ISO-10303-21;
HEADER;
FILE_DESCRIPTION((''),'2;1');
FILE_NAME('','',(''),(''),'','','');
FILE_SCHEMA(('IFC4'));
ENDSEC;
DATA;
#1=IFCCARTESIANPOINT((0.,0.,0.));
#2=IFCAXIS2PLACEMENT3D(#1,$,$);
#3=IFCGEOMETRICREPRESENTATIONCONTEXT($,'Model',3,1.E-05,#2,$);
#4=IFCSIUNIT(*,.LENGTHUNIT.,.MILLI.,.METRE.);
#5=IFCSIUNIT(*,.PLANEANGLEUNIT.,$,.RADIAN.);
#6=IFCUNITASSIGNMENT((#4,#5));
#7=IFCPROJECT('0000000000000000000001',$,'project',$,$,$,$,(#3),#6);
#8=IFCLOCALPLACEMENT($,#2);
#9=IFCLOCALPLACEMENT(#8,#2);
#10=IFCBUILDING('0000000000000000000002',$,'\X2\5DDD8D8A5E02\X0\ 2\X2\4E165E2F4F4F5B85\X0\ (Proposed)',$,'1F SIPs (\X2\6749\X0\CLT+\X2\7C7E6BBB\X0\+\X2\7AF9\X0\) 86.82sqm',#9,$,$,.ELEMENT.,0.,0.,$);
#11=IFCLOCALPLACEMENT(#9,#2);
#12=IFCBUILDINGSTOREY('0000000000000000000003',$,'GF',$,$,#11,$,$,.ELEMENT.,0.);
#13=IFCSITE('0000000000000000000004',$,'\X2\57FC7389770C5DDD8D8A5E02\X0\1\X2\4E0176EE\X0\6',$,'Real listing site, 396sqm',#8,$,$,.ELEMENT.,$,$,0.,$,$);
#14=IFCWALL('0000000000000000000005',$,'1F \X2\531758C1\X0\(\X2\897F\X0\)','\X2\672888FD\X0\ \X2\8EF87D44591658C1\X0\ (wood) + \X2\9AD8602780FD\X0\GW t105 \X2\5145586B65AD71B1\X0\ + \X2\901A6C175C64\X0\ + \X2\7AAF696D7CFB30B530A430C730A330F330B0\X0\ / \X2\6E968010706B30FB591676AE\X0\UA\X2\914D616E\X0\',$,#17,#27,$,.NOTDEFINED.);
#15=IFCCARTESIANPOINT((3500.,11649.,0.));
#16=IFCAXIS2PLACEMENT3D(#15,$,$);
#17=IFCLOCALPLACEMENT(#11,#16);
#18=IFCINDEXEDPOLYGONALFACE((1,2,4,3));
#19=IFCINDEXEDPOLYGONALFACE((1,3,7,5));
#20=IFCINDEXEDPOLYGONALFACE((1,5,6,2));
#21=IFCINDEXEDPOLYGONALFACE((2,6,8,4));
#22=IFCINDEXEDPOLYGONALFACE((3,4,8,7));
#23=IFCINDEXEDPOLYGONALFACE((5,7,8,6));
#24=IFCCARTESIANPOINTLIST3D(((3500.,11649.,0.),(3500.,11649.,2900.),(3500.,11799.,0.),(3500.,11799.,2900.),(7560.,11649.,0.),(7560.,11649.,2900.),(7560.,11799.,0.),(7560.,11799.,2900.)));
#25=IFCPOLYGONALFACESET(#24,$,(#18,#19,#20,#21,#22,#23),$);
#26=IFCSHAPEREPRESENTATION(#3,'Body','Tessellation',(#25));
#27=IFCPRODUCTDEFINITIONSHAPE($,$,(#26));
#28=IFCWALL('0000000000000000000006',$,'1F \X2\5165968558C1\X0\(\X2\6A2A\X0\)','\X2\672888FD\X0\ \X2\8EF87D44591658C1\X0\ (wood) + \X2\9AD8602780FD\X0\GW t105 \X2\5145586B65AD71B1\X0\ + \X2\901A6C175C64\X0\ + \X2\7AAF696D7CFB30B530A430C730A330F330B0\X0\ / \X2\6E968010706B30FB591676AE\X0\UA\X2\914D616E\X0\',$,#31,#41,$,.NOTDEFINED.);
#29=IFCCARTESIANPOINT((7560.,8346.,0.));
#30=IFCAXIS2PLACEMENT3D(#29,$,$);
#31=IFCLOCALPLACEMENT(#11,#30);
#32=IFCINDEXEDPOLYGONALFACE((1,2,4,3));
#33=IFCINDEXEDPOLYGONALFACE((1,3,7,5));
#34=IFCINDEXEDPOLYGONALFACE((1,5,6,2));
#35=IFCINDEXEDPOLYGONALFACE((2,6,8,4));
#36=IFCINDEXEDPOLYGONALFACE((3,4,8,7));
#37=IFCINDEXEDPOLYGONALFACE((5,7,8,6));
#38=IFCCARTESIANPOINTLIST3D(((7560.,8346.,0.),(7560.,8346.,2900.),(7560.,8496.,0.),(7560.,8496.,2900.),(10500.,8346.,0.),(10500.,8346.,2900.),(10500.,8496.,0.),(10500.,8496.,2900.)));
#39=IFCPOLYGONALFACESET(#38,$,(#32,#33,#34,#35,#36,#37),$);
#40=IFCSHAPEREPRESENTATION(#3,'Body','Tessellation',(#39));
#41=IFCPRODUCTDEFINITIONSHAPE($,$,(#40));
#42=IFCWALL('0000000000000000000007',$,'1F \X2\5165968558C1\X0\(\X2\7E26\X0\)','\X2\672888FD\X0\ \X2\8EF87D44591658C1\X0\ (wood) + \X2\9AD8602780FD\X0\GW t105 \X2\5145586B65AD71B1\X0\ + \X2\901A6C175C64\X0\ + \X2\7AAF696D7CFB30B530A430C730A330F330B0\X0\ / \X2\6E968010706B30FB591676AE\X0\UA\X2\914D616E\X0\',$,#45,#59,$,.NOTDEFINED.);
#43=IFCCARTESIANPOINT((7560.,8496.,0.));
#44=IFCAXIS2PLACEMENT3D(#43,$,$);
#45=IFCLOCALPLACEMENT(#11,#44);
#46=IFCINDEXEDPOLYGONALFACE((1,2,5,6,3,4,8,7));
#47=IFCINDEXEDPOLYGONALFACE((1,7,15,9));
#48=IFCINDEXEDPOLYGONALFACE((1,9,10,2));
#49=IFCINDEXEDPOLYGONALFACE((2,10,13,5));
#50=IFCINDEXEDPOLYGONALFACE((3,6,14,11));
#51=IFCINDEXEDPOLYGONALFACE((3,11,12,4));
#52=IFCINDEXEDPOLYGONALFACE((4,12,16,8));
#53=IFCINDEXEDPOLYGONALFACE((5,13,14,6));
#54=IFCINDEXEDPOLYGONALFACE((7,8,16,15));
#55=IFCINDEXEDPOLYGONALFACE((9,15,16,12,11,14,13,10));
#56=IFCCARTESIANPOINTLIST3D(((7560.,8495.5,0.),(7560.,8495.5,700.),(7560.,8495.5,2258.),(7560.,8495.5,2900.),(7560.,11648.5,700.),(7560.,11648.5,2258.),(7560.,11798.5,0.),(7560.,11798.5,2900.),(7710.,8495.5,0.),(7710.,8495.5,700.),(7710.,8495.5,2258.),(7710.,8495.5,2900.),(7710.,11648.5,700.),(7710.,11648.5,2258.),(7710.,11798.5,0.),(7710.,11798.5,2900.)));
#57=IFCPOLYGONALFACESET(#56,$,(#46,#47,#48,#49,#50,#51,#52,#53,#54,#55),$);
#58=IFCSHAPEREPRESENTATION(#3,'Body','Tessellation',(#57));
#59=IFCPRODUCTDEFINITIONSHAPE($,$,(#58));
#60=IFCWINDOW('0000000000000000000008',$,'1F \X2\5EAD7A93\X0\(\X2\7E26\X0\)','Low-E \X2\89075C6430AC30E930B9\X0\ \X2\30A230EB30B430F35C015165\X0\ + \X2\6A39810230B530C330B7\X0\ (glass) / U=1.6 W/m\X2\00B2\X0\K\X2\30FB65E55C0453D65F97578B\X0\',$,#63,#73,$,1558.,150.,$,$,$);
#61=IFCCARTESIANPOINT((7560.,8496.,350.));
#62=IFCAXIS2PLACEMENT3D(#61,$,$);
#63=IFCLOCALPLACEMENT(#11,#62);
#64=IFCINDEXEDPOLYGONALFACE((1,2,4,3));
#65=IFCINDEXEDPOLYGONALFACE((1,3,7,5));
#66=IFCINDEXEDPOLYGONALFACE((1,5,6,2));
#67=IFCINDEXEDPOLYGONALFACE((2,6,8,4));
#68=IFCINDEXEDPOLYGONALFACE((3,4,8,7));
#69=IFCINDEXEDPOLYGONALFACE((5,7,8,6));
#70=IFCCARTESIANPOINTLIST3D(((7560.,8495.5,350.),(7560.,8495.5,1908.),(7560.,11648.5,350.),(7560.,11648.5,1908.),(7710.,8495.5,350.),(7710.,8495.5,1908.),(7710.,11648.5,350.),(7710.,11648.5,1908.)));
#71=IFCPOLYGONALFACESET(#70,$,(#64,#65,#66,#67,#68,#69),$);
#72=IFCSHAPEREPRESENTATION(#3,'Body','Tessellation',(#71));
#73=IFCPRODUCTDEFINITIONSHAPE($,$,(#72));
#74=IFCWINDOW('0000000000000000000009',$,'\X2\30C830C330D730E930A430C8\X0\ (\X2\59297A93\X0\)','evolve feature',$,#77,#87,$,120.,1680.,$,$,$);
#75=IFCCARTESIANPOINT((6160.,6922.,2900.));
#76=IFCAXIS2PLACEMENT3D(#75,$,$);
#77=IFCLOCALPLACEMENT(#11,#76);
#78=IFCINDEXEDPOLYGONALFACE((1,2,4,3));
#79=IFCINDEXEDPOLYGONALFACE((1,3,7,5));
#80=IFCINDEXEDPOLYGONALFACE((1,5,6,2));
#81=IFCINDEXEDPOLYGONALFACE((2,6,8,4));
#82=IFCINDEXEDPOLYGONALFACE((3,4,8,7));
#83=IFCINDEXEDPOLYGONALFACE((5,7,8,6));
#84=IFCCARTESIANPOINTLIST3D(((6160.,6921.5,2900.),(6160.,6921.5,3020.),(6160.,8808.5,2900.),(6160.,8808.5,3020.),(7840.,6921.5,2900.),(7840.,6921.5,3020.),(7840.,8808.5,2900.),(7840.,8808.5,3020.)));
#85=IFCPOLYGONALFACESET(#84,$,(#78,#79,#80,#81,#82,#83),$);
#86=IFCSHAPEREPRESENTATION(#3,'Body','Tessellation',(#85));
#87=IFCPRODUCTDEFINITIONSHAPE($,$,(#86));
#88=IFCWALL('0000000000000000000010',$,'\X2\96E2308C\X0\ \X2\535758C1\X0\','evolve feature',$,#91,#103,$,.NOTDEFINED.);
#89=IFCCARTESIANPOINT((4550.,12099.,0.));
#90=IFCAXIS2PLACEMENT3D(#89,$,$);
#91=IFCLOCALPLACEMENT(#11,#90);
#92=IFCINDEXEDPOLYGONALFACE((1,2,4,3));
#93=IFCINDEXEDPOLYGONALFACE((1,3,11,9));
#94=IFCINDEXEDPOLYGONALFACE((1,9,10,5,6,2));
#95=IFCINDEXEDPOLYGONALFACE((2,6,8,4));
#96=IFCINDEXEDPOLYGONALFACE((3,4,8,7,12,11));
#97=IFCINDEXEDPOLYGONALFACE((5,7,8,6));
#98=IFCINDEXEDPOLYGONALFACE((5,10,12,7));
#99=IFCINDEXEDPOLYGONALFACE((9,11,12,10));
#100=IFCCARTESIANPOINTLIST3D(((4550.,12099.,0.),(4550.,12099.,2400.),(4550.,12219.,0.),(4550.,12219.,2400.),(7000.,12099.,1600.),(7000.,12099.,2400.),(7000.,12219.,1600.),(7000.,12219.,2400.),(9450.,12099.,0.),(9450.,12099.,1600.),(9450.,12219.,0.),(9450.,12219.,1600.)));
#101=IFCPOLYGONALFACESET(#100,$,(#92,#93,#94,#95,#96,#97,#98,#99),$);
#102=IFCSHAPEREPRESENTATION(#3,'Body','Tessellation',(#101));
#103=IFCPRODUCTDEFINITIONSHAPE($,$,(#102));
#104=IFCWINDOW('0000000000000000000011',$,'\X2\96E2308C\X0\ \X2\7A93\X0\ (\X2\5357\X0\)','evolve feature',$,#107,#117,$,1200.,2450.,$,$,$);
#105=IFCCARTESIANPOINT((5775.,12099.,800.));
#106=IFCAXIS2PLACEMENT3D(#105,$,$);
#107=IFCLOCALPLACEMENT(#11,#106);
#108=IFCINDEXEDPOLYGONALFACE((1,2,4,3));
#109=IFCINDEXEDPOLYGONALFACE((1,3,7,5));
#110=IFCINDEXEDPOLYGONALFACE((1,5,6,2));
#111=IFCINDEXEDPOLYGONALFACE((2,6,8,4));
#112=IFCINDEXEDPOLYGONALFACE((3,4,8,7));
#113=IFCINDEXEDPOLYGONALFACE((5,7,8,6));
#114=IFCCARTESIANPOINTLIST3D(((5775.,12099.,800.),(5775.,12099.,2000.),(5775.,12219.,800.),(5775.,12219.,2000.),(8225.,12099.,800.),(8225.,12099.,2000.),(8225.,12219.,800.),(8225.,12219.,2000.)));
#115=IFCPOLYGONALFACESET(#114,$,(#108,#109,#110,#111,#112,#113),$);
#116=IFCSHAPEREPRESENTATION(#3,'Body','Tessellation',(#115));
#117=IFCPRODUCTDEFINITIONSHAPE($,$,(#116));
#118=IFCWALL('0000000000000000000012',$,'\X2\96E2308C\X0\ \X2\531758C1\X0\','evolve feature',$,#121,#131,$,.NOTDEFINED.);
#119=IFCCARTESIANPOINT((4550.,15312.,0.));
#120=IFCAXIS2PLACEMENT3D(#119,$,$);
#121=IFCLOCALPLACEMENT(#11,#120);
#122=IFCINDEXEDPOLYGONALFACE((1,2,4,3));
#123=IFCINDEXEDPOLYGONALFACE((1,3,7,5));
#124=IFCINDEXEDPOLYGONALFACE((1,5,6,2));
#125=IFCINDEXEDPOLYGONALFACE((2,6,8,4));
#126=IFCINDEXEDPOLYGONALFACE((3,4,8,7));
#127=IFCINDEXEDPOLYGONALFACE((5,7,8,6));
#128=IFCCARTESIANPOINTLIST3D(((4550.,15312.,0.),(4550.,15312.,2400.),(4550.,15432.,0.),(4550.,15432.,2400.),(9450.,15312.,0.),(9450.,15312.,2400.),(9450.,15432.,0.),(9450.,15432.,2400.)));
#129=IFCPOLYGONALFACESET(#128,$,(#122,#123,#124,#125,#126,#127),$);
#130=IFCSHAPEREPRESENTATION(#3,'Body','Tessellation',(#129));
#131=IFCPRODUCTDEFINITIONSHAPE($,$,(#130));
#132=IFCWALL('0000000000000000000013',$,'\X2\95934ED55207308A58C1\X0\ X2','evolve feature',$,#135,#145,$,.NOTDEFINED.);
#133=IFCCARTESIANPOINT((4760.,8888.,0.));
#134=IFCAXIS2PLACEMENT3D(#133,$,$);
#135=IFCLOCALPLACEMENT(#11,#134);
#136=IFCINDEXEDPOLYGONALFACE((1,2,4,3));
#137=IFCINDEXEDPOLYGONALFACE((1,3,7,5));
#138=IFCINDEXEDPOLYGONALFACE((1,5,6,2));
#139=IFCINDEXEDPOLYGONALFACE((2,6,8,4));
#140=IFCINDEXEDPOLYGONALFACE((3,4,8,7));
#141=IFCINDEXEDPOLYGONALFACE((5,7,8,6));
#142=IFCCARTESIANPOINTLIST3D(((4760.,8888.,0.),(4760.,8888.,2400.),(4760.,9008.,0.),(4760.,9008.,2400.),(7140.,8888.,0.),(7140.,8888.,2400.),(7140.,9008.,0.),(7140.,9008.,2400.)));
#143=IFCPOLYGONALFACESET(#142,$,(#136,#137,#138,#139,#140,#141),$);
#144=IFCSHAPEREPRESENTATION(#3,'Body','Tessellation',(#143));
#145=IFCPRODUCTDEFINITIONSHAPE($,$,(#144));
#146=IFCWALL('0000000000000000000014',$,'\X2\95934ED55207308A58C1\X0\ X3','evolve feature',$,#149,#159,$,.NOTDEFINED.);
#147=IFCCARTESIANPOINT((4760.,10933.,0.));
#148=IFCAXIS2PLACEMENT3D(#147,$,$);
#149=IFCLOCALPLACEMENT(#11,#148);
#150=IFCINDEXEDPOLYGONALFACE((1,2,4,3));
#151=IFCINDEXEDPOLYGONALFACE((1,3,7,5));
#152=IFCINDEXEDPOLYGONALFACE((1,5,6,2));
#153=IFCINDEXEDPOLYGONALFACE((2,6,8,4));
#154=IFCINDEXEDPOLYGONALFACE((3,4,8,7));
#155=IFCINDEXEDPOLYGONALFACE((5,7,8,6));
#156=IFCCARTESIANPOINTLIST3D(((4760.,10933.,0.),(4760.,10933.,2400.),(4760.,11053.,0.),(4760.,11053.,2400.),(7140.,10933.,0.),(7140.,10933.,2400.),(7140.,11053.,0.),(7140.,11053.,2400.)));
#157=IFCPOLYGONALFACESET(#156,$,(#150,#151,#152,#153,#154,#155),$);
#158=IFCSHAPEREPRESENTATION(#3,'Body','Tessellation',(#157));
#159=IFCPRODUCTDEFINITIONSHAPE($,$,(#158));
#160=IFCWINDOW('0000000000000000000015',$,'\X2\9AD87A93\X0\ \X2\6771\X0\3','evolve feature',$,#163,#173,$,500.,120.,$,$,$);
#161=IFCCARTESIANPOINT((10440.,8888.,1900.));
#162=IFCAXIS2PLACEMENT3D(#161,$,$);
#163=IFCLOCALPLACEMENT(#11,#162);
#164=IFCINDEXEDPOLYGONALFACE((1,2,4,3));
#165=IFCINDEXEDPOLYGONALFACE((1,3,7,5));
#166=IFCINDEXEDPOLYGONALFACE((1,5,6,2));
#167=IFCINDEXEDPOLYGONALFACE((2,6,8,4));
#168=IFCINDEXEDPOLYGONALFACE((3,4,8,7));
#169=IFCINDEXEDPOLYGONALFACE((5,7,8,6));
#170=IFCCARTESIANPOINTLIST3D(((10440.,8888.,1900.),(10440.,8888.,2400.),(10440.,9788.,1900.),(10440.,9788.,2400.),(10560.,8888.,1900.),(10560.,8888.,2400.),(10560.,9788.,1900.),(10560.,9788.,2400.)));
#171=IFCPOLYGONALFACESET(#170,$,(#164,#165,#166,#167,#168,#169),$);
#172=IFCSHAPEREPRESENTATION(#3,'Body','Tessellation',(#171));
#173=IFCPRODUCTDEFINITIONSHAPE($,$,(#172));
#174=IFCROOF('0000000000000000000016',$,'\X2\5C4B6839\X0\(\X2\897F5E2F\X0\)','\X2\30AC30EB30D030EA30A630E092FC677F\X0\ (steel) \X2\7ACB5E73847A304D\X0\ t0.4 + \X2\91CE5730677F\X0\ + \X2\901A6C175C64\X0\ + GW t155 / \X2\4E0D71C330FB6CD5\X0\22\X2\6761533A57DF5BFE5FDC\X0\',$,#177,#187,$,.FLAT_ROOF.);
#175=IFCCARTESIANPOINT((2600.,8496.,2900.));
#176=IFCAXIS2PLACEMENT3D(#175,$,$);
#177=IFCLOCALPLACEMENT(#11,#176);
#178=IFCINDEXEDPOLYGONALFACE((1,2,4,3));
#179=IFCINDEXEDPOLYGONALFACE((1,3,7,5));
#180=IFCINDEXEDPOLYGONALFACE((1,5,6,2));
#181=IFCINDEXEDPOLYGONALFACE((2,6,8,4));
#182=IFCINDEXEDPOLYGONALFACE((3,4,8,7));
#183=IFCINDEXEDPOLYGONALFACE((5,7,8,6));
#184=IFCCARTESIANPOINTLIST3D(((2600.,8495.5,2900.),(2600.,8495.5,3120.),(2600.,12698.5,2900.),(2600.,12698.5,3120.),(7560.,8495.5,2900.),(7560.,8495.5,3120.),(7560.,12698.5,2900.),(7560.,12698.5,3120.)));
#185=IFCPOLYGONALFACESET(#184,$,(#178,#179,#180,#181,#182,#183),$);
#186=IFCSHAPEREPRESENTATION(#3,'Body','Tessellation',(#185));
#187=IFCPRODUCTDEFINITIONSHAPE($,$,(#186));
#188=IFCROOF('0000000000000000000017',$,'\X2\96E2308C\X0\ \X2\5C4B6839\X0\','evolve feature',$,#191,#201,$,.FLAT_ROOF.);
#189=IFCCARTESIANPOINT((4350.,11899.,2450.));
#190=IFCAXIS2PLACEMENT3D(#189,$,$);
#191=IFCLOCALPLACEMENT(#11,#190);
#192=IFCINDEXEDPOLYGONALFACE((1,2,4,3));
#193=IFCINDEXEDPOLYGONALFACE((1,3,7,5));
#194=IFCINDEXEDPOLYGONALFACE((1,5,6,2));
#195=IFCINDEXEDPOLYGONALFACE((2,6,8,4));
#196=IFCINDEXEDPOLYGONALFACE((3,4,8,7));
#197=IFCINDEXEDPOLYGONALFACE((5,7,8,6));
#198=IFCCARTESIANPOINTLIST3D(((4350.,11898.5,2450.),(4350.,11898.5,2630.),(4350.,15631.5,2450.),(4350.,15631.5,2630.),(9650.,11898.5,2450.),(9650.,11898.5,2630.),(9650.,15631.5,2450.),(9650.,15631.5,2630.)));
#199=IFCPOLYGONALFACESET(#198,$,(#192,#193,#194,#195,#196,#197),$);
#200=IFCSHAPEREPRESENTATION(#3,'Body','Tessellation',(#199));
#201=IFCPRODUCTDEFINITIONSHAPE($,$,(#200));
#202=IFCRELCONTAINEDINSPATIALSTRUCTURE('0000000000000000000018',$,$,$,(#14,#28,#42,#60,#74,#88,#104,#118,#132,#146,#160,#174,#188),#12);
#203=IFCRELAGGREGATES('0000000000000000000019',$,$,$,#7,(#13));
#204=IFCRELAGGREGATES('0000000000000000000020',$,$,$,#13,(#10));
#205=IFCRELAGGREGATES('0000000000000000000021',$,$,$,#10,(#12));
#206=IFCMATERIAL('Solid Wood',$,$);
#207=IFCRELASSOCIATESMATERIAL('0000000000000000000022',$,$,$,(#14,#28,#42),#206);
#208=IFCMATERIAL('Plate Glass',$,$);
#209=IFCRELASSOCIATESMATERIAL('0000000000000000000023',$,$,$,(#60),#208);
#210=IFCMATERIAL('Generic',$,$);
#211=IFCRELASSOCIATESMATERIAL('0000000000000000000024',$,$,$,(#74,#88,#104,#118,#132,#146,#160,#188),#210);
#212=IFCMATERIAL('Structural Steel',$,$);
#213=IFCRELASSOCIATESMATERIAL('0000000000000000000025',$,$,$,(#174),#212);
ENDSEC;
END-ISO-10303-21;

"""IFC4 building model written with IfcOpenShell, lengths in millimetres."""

from ifc_helpers import new_model, si_unit, frame, frame_2d, origin, place, context, project, spatial, rectangle, extrude, material, element, fill, save


model = new_model("IFC4")

# Units and contexts
model_context = context("Model", 3, precision=1e-05, world=origin())
ifc_project = project(units=[si_unit("LENGTHUNIT", "METRE", prefix="MILLI"), si_unit("PLANEANGLEUNIT", "RADIAN")], contexts=[model_context])

# Site, building, storey
site_placement = place(None, origin())
site = spatial("IfcSite", under=ifc_project, at=site_placement, Name="埼玉県川越市1丁目6", ObjectType="Real listing site, 396sqm", CompositionType="ELEMENT", RefElevation=0.0)
building_placement = place(site_placement, origin())
building = spatial("IfcBuilding", under=site, at=building_placement, Name="川越市 2世帯住宅 (Proposed)", ObjectType="1F SIPs (杉CLT+籾殻+竹) 86.82sqm", CompositionType="ELEMENT", ElevationOfRefHeight=0.0, ElevationOfTerrain=0.0)
storey_placement = place(building_placement, origin())
storey = spatial("IfcBuildingStorey", under=building, at=storey_placement, Name="GF", CompositionType="ELEMENT", Elevation=0.0)

# Shared definitions
ifc_material_1 = material(Name="Solid Wood")
ifc_material_2 = material(Name="Generic")

# Walls
wall_1_placement = place(storey_placement, frame((3500.0, 11649.0, 0.0)))
element("IfcWall", 1, at=wall_1_placement, inside=storey, material=ifc_material_1, Name="1F 北壁(西)", Description="木製 軸組外壁 (wood) + 高性能GW t105 充填断熱 + 通気層 + 窯業系サイディング / 準耐火・外皮UA配慮", PredefinedType="NOTDEFINED", context=model_context, shape_type="SweptSolid", body=[
    extrude(rectangle(XDim=4060.0, YDim=150.0, at=frame_2d((2030.0, 75.0))), frame((3500.0, 11649.0, 0.0)), (0.0, 0.0, 1.0), 2900.0),
])
wall_2_placement = place(storey_placement, frame((7560.0, 8346.0, 0.0)))
element("IfcWall", 2, at=wall_2_placement, inside=storey, material=ifc_material_1, Name="1F 入隅壁(横)", Description="木製 軸組外壁 (wood) + 高性能GW t105 充填断熱 + 通気層 + 窯業系サイディング / 準耐火・外皮UA配慮", PredefinedType="NOTDEFINED", context=model_context, shape_type="SweptSolid", body=[
    extrude(rectangle(XDim=2940.0, YDim=150.0, at=frame_2d((1470.0, 75.0))), frame((7560.0, 8346.0, 0.0)), (0.0, 0.0, 1.0), 2900.0),
])

# Wall, opening, window
wall_3_placement = place(storey_placement, frame((7560.0, 8496.0, 0.0)))
wall_3 = element("IfcWall", 3, at=wall_3_placement, inside=storey, material=ifc_material_1, Name="1F 入隅壁(縦)", Description="木製 軸組外壁 (wood) + 高性能GW t105 充填断熱 + 通気層 + 窯業系サイディング / 準耐火・外皮UA配慮", PredefinedType="NOTDEFINED", context=model_context, shape_type="SweptSolid", body=[
    extrude(rectangle(XDim=150.0, YDim=3303.0, at=frame_2d((75.0, 1651.0))), frame((7560.0, 8496.0, 0.0)), (0.0, 0.0, 1.0), 2900.0),
])
opening_1_placement = place(storey_placement, frame((7560.0, 8496.0, 350.0)))
opening_1 = element("IfcOpeningElement", 4, at=opening_1_placement, cuts=wall_3, PredefinedType="NOTDEFINED", context=model_context, shape_type="SweptSolid", body=[
    extrude(rectangle(XDim=150.0, YDim=3153.0, at=frame_2d((75.0, 1576.0))), frame((7560.0, 8496.0, 350.0)), (0.0, 0.0, 1.0), 1558.0),
])
ifc_material_3 = material(Name="Plate Glass")
window_1_placement = place(storey_placement, frame((7560.0, 8496.0, 350.0)))
window_1 = element("IfcWindow", 5, at=window_1_placement, inside=storey, material=ifc_material_3, Name="1F 庭窓(縦)", Description="Low-E 複層ガラス アルゴン封入 + 樹脂サッシ (glass) / U=1.6 W/m²K・日射取得型", OverallHeight=1558.0, OverallWidth=150.0, context=model_context, shape_type="SweptSolid", body=[
    extrude(rectangle(XDim=150.0, YDim=3153.0, at=frame_2d((75.0, 1576.0))), frame((7560.0, 8496.0, 350.0)), (0.0, 0.0, 1.0), 1558.0),
])
fill(opening_1, window_1)

# Window
window_2_placement = place(storey_placement, frame((6160.0, 6922.0, 2900.0)))
element("IfcWindow", 6, at=window_2_placement, inside=storey, material=ifc_material_2, Name="トップライト (天窓)", Description="evolve feature", OverallHeight=120.0, OverallWidth=1680.0, context=model_context, shape_type="SweptSolid", body=[
    extrude(rectangle(XDim=1680.0, YDim=1887.0, at=frame_2d((840.0, 943.0))), frame((6160.0, 6922.0, 2900.0)), (0.0, 0.0, 1.0), 120.0),
])

# Wall, opening, window
wall_4_placement = place(storey_placement, frame((4550.0, 12099.0, 0.0)))
wall_4 = element("IfcWall", 7, at=wall_4_placement, inside=storey, material=ifc_material_2, Name="離れ 南壁", Description="evolve feature", PredefinedType="NOTDEFINED", context=model_context, shape_type="SweptSolid", body=[
    extrude(rectangle(XDim=4900.0, YDim=120.0, at=frame_2d((2450.0, 60.0))), frame((4550.0, 12099.0, 0.0)), (0.0, 0.0, 1.0), 2400.0),
])
opening_2_placement = place(storey_placement, frame((5775.0, 12099.0, 800.0)))
opening_2 = element("IfcOpeningElement", 8, at=opening_2_placement, cuts=wall_4, PredefinedType="NOTDEFINED", context=model_context, shape_type="SweptSolid", body=[
    extrude(rectangle(XDim=2450.0, YDim=120.0, at=frame_2d((1225.0, 60.0))), frame((5775.0, 12099.0, 800.0)), (0.0, 0.0, 1.0), 1200.0),
])
window_3_placement = place(storey_placement, frame((5775.0, 12099.0, 800.0)))
window_3 = element("IfcWindow", 9, at=window_3_placement, inside=storey, material=ifc_material_2, Name="離れ 窓 (南)", Description="evolve feature", OverallHeight=1200.0, OverallWidth=2450.0, context=model_context, shape_type="SweptSolid", body=[
    extrude(rectangle(XDim=2450.0, YDim=120.0, at=frame_2d((1225.0, 60.0))), frame((5775.0, 12099.0, 800.0)), (0.0, 0.0, 1.0), 1200.0),
])
fill(opening_2, window_3)

# Walls
wall_5_placement = place(storey_placement, frame((4550.0, 15312.0, 0.0)))
element("IfcWall", 10, at=wall_5_placement, inside=storey, material=ifc_material_2, Name="離れ 北壁", Description="evolve feature", PredefinedType="NOTDEFINED", context=model_context, shape_type="SweptSolid", body=[
    extrude(rectangle(XDim=4900.0, YDim=120.0, at=frame_2d((2450.0, 60.0))), frame((4550.0, 15312.0, 0.0)), (0.0, 0.0, 1.0), 2400.0),
])
wall_6_placement = place(storey_placement, frame((4760.0, 8888.0, 0.0)))
element("IfcWall", 11, at=wall_6_placement, inside=storey, material=ifc_material_2, Name="間仕切り壁 X2", Description="evolve feature", PredefinedType="NOTDEFINED", context=model_context, shape_type="SweptSolid", body=[
    extrude(rectangle(XDim=2380.0, YDim=120.0, at=frame_2d((1190.0, 60.0))), frame((4760.0, 8888.0, 0.0)), (0.0, 0.0, 1.0), 2400.0),
])
wall_7_placement = place(storey_placement, frame((4760.0, 10933.0, 0.0)))
element("IfcWall", 12, at=wall_7_placement, inside=storey, material=ifc_material_2, Name="間仕切り壁 X3", Description="evolve feature", PredefinedType="NOTDEFINED", context=model_context, shape_type="SweptSolid", body=[
    extrude(rectangle(XDim=2380.0, YDim=120.0, at=frame_2d((1190.0, 60.0))), frame((4760.0, 10933.0, 0.0)), (0.0, 0.0, 1.0), 2400.0),
])

# Window
window_4_placement = place(storey_placement, frame((10440.0, 8888.0, 1900.0)))
element("IfcWindow", 13, at=window_4_placement, inside=storey, material=ifc_material_2, Name="高窓 東3", Description="evolve feature", OverallHeight=500.0, OverallWidth=120.0, context=model_context, shape_type="SweptSolid", body=[
    extrude(rectangle(XDim=120.0, YDim=900.0, at=frame_2d((60.0, 450.0))), frame((10440.0, 8888.0, 1900.0)), (0.0, 0.0, 1.0), 500.0),
])

# Roofs
ifc_material_4 = material(Name="Structural Steel")
roof_1_placement = place(storey_placement, frame((2600.0, 8496.0, 2900.0)))
element("IfcRoof", 14, at=roof_1_placement, inside=storey, material=ifc_material_4, Name="屋根(西帯)", Description="ガルバリウム鋼板 (steel) 立平葺き t0.4 + 野地板 + 通気層 + GW t155 / 不燃・法22条区域対応", PredefinedType="FLAT_ROOF", context=model_context, shape_type="SweptSolid", body=[
    extrude(rectangle(XDim=4960.0, YDim=4203.0, at=frame_2d((2480.0, 2101.0))), frame((2600.0, 8496.0, 2900.0)), (0.0, 0.0, 1.0), 220.0),
])
roof_2_placement = place(storey_placement, frame((4350.0, 11899.0, 2450.0)))
element("IfcRoof", 15, at=roof_2_placement, inside=storey, material=ifc_material_2, Name="離れ 屋根", Description="evolve feature", PredefinedType="FLAT_ROOF", context=model_context, shape_type="SweptSolid", body=[
    extrude(rectangle(XDim=5300.0, YDim=3733.0, at=frame_2d((2650.0, 1866.0))), frame((4350.0, 11899.0, 2450.0)), (0.0, 0.0, 1.0), 180.0),
])

save(model, "model.ifc")
